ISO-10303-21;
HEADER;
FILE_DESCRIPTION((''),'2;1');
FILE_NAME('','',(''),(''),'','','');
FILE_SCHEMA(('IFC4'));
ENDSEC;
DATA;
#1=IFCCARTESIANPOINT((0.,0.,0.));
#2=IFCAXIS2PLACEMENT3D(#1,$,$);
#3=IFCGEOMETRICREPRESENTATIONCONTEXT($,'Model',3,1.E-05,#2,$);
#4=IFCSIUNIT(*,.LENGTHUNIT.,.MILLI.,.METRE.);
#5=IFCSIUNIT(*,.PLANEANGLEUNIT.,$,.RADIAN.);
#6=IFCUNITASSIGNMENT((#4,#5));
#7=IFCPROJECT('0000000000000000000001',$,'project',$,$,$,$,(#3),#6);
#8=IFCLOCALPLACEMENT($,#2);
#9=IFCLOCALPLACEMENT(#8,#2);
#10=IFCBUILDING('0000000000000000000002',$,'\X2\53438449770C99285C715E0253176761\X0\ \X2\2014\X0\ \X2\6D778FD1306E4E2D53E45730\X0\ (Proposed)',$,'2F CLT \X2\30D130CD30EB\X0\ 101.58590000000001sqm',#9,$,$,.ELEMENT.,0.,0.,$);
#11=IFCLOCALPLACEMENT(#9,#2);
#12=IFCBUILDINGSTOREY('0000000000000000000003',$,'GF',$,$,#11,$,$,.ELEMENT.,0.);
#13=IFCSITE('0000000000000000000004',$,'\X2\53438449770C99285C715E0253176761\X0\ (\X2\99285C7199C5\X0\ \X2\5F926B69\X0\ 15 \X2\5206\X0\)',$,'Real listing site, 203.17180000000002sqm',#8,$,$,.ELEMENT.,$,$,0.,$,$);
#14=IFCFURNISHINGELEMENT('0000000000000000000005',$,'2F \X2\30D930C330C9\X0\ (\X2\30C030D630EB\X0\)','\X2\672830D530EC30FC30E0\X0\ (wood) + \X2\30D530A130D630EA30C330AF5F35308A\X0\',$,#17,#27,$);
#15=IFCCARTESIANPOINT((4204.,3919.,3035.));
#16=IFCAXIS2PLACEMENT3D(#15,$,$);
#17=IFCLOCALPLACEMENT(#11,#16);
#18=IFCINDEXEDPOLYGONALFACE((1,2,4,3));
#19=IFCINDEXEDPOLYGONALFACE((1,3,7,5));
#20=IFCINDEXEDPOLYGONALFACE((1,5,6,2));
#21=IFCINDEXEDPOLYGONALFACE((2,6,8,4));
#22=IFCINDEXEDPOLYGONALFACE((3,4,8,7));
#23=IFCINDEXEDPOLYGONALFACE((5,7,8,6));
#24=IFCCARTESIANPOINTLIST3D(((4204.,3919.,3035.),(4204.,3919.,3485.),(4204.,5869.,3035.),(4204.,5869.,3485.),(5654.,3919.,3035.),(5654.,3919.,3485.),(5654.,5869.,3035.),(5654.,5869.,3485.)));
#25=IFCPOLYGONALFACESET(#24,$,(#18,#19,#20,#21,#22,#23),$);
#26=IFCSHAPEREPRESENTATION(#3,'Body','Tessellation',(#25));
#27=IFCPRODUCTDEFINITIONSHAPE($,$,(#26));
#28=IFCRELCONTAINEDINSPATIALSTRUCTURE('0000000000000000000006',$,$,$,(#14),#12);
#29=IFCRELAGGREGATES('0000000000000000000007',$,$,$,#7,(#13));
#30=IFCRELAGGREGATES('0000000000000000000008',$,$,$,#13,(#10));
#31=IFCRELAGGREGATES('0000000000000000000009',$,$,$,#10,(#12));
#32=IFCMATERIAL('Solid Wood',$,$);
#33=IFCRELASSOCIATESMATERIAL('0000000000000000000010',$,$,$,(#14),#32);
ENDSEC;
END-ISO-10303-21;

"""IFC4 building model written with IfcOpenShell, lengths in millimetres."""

from ifc_helpers import new_model, si_unit, frame, frame_2d, origin, place, context, project, spatial, rectangle, extrude, material, element, save


model = new_model("IFC4")

# Units and contexts
model_context = context("Model", 3, precision=1e-05, world=origin())
ifc_project = project(units=[si_unit("LENGTHUNIT", "METRE", prefix="MILLI"), si_unit("PLANEANGLEUNIT", "RADIAN")], contexts=[model_context])

# Site, building, storey
site_placement = place(None, origin())
site = spatial("IfcSite", under=ifc_project, at=site_placement, Name="千葉県館山市北条 (館山駅 徒歩 15 分)", ObjectType="Real listing site, 203.17180000000002sqm", CompositionType="ELEMENT", RefElevation=0.0)
building_placement = place(site_placement, origin())
building = spatial("IfcBuilding", under=site, at=building_placement, Name="千葉県館山市北条 — 海近の中古地 (Proposed)", ObjectType="2F CLT パネル 101.58590000000001sqm", CompositionType="ELEMENT", ElevationOfRefHeight=0.0, ElevationOfTerrain=0.0)
storey_placement = place(building_placement, origin())
storey = spatial("IfcBuildingStorey", under=building, at=storey_placement, Name="GF", CompositionType="ELEMENT", Elevation=0.0)

# Shared definitions
ifc_material_1 = material(Name="Solid Wood")

# Furnishing element
furnishing_placement = place(storey_placement, frame((4204.0, 3919.0, 3035.0)))
element("IfcFurnishingElement", 1, at=furnishing_placement, inside=storey, material=ifc_material_1, Name="2F ベッド (ダブル)", Description="木フレーム (wood) + ファブリック張り", context=model_context, shape_type="SweptSolid", body=[
    extrude(rectangle(XDim=1450.0, YDim=1950.0, at=frame_2d((725.0, 975.0))), frame((4204.0, 3919.0, 3035.0)), (0.0, 0.0, 1.0), 450.0),
])

save(model, "model.ifc")
